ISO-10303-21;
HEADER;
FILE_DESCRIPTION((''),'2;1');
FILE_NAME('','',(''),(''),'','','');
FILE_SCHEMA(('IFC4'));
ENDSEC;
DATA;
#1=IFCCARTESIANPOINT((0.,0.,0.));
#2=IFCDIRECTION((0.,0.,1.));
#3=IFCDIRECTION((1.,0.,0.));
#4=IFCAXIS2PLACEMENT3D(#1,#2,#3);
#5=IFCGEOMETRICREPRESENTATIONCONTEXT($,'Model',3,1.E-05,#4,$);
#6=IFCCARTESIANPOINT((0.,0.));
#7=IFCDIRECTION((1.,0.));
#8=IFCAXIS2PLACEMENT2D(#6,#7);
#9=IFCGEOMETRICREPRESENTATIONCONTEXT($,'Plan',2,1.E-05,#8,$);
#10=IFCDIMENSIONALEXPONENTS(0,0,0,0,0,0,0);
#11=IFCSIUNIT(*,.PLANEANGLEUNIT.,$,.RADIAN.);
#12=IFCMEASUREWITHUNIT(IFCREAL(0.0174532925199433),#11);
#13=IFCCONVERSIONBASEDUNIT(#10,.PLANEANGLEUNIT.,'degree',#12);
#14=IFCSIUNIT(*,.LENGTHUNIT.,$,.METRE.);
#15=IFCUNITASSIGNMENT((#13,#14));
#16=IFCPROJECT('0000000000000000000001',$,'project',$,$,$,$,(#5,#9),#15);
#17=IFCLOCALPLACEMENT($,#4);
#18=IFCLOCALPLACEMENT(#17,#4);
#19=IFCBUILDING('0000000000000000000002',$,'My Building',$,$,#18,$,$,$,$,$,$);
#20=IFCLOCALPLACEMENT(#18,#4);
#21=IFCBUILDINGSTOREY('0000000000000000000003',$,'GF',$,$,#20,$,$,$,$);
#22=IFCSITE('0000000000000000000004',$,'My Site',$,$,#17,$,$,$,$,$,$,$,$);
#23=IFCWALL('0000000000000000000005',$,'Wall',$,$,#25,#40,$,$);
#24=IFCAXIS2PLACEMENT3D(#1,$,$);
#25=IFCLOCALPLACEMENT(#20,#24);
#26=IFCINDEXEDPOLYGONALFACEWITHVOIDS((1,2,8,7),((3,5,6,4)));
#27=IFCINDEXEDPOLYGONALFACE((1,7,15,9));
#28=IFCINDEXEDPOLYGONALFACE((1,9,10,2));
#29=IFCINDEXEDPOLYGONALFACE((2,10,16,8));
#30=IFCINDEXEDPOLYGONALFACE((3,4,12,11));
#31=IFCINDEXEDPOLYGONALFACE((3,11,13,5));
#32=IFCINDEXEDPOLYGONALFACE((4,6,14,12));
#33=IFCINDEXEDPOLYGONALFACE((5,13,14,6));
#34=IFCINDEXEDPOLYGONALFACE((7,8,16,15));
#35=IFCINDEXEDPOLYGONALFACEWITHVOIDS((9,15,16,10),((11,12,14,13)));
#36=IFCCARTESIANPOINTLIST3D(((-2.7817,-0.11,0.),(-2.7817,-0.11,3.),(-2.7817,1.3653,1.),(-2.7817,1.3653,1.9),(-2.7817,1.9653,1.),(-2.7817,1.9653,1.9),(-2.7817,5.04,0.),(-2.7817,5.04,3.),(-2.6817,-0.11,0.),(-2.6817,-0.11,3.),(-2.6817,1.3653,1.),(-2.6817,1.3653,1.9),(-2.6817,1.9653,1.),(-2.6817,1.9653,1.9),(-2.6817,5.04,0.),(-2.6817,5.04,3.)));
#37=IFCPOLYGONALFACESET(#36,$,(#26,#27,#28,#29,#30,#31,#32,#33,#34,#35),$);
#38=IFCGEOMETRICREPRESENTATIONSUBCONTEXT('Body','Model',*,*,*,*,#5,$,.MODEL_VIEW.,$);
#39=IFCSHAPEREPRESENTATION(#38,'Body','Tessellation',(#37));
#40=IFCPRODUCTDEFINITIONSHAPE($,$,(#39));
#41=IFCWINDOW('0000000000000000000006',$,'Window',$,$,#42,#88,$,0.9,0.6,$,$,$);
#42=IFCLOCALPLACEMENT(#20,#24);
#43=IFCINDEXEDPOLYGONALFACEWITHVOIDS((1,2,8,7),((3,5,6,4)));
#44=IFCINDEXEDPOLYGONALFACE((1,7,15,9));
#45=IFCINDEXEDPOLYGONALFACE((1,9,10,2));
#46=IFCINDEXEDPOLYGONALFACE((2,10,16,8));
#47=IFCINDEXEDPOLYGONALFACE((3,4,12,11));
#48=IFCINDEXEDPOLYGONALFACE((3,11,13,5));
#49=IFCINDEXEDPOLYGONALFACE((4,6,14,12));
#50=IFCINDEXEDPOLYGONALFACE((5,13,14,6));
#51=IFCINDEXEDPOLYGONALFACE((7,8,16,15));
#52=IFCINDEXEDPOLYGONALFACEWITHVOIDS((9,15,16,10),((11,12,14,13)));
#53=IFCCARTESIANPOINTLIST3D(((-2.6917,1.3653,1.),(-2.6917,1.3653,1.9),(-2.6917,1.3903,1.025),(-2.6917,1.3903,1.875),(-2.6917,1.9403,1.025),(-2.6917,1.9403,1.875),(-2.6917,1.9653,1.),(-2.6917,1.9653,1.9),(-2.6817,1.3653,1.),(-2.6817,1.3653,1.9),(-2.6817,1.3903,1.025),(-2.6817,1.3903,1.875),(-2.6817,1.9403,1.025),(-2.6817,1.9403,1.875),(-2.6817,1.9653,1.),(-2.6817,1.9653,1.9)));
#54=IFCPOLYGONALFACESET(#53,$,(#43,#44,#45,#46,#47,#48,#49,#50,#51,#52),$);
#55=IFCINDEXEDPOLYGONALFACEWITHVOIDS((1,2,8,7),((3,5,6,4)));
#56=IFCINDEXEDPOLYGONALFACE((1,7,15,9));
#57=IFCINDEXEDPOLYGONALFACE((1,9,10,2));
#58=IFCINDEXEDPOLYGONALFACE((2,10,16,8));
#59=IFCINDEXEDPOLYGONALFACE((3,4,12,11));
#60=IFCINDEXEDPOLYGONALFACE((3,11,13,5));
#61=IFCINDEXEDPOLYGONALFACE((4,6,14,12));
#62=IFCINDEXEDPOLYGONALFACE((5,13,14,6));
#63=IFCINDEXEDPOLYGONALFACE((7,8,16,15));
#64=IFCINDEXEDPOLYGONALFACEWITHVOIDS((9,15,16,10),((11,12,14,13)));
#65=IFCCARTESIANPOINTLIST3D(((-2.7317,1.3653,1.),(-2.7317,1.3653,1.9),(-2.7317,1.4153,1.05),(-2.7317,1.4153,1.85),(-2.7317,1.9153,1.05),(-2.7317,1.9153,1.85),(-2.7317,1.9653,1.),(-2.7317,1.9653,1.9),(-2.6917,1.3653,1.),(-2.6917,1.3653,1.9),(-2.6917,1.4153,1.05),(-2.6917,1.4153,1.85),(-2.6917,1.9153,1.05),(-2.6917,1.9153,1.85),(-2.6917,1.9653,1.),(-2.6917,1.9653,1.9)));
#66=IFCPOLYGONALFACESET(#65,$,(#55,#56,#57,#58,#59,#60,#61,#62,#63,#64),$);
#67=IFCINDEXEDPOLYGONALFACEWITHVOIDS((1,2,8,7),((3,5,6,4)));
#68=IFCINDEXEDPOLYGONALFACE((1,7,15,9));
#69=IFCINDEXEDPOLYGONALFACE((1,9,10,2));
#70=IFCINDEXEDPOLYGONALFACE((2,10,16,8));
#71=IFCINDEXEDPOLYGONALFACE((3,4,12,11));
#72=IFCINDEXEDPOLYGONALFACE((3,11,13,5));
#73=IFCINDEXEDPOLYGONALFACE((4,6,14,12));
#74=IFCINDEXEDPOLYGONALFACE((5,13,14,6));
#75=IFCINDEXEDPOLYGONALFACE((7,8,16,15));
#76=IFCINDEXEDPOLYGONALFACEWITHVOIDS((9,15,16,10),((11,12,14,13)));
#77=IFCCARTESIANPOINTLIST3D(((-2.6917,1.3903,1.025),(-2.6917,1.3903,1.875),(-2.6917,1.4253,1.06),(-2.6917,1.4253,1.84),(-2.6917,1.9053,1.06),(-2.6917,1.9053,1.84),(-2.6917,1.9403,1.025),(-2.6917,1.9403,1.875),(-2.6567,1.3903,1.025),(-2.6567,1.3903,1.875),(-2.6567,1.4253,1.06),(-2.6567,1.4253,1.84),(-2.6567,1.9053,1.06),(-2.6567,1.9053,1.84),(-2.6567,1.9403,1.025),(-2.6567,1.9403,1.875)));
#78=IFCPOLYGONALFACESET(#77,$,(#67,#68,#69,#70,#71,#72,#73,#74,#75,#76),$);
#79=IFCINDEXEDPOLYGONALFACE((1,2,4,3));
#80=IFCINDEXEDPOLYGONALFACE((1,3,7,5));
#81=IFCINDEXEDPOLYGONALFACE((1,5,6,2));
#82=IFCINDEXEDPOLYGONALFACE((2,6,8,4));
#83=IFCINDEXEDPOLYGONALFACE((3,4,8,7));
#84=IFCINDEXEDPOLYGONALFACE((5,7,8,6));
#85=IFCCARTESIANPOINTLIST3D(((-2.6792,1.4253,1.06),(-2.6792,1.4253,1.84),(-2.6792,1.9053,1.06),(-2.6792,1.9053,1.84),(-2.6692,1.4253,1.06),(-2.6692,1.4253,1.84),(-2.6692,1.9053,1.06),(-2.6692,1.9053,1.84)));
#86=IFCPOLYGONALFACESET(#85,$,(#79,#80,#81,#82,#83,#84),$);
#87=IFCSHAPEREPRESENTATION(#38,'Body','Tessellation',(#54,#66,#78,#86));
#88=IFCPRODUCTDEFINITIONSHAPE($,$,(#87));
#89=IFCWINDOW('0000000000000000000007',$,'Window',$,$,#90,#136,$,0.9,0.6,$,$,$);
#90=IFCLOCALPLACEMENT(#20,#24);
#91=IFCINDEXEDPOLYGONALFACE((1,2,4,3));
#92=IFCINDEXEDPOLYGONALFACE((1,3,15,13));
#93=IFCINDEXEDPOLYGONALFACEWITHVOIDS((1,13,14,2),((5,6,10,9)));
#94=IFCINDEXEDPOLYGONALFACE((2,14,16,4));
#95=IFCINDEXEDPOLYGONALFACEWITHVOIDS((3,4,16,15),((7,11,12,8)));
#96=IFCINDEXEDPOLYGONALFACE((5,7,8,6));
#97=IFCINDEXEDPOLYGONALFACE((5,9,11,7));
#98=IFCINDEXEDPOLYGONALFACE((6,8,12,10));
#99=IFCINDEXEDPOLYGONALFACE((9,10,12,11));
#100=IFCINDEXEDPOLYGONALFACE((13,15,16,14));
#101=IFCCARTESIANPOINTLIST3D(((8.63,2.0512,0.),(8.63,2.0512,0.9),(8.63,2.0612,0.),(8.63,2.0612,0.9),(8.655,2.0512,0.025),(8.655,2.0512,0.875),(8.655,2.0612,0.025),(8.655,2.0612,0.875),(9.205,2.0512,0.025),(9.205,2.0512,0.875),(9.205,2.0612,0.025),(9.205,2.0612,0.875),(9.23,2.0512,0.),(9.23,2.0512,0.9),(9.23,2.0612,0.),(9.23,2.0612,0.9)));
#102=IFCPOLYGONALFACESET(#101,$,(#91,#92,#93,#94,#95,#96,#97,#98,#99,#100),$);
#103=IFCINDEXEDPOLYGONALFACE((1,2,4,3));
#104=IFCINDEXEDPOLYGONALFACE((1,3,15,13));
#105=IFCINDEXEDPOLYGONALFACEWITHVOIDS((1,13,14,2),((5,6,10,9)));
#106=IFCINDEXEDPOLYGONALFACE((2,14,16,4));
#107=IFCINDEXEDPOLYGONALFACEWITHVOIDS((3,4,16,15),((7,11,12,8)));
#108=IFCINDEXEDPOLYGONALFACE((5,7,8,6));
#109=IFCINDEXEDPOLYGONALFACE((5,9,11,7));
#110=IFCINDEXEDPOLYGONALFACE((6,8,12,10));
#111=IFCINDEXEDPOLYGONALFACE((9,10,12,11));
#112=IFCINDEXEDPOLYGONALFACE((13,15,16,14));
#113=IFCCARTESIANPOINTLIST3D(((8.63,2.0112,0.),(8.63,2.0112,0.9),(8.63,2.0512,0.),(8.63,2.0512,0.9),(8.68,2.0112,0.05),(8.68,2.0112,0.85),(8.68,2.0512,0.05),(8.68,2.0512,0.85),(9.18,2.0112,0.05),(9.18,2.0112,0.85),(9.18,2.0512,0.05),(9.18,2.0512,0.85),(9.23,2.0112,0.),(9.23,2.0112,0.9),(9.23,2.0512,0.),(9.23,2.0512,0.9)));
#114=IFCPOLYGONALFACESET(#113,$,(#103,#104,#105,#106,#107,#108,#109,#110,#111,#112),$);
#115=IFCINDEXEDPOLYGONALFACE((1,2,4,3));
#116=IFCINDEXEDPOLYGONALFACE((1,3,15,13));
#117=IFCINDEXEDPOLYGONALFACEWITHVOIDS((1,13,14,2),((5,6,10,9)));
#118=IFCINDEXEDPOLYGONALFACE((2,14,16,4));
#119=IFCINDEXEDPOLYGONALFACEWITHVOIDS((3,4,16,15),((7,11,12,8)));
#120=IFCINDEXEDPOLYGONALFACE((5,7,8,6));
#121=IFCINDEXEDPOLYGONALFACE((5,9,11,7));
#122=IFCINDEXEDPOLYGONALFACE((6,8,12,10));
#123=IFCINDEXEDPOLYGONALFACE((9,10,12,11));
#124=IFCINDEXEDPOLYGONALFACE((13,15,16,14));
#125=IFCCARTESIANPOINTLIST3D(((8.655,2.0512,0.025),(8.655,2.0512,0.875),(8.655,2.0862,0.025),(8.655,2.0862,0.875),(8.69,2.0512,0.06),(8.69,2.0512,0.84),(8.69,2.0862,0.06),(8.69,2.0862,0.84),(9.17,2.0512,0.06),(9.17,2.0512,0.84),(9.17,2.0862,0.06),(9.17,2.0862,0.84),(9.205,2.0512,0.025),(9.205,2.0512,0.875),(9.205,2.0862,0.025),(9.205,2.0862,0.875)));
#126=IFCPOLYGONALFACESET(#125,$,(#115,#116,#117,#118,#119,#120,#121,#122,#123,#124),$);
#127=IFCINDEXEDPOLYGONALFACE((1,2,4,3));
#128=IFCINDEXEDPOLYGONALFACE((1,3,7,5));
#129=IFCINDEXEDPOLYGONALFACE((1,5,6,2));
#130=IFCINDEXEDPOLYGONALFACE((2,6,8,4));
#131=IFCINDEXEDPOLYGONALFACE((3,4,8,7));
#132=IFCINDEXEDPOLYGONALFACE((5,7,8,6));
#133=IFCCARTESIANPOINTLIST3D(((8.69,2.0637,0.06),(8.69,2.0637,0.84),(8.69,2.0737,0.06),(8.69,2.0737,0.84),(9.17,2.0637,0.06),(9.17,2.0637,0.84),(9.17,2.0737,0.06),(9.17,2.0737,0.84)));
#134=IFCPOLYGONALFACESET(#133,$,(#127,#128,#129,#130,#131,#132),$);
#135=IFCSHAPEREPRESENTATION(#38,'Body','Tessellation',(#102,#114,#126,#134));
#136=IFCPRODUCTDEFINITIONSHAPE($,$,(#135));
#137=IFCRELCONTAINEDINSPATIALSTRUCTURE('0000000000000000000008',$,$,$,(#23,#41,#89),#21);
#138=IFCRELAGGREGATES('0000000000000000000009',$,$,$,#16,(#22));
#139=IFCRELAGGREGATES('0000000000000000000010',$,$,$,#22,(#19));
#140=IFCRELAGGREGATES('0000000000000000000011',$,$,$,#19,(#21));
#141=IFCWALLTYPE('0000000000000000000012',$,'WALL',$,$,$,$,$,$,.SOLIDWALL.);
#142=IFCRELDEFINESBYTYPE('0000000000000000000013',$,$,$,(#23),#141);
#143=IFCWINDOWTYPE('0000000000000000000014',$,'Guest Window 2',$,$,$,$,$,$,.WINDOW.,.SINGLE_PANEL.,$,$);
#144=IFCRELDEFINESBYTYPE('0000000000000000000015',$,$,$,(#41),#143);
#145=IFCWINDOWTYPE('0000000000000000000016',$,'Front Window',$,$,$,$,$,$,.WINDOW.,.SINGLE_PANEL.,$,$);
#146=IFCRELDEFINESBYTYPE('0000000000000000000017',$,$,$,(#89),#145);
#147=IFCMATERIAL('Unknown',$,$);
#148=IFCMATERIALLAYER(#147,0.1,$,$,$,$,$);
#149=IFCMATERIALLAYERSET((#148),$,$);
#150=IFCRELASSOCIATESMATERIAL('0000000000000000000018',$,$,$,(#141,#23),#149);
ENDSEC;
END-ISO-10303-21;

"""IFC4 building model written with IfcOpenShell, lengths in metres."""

from ifc_helpers import new_model, entity, si_unit, converted_unit, frame, origin_with_axes, origin_2d_with_axis, place, context, subcontext, project, spatial, line, indexed_curve, outline, extrude, shape, source, transform, mapped, material, layer, layer_set, layer_usage, type_object, type_shapes, element, fill, save


model = new_model("IFC4")

# Units and contexts
model_context = context("Model", 3, precision=1e-05, world=origin_with_axes())
plan_context = context("Plan", 2, precision=1e-05, world=origin_2d_with_axis())
body_context_1 = subcontext(model_context, "Body", "Model", "MODEL_VIEW")
body_context_2 = subcontext(plan_context, "Body", "Plan", "PLAN_VIEW")
ifc_project = project(units=[converted_unit("PLANEANGLEUNIT", "degree", entity("IfcReal", 0.0174532925199433), si_unit("PLANEANGLEUNIT", "RADIAN"), dimensions=[0, 0, 0, 0, 0, 0, 0]), si_unit("LENGTHUNIT", "METRE")], contexts=[model_context, plan_context])

# Site, building, storey
site_placement = place(None, origin_with_axes())
site = spatial("IfcSite", under=ifc_project, at=site_placement, Name="My Site")
building_placement = place(site_placement, origin_with_axes())
building = spatial("IfcBuilding", under=site, at=building_placement, Name="My Building")
storey_placement = place(building_placement, origin_with_axes())
storey = spatial("IfcBuildingStorey", under=building, at=storey_placement, Name="GF")

# Shared definitions
ifc_material = material(Name="Unknown")
ifc_layer = layer(ifc_material, 0.1)
ifc_layer_set = layer_set([ifc_layer])
wall_type = type_object("IfcWallType", Name="WALL", PredefinedType="SOLIDWALL", material=ifc_layer_set)
window_type_1 = type_object("IfcWindowType", Name="Front Window", PartitioningType="SINGLE_PANEL", PredefinedType="WINDOW")
shared_shape_1 = source(origin_with_axes(), body_context_1, "Body", "SweptSolid", [
    extrude(outline(indexed_curve([(0.0, 0.0), (0.6, 0.0), (0.6, 0.9), (0.0, 0.9)], segments=[line(1, 2, 3, 4, 1)]), holes=[indexed_curve([(0.025, 0.025), (0.575, 0.025), (0.575, 0.875), (0.025, 0.875)], segments=[line(1, 2, 3, 4, 1)])]), frame((0.0, 0.09, 0.0), z_axis=(0.0, -1.0, 0.0), x_axis=(1.0, 0.0, 0.0)), (0.0, 0.0, -1.0), 0.01),
    extrude(outline(indexed_curve([(0.0, 0.0), (0.6, 0.0), (0.6, 0.9), (0.0, 0.9)], segments=[line(1, 2, 3, 4, 1)]), holes=[indexed_curve([(0.05, 0.05), (0.55, 0.05), (0.55, 0.85), (0.05, 0.85)], segments=[line(1, 2, 3, 4, 1)])]), frame((0.0, 0.05, 0.0), z_axis=(0.0, -1.0, 0.0), x_axis=(1.0, 0.0, 0.0)), (0.0, 0.0, -1.0), 0.04),
    extrude(outline(indexed_curve([(0.0, 0.0), (0.55, 0.0), (0.55, 0.85), (0.0, 0.85)], segments=[line(1, 2, 3, 4, 1)]), holes=[indexed_curve([(0.035, 0.035), (0.515, 0.035), (0.515, 0.815), (0.035, 0.815)], segments=[line(1, 2, 3, 4, 1)])]), frame((0.025, 0.09, 0.025), z_axis=(0.0, -1.0, 0.0), x_axis=(1.0, 0.0, 0.0)), (0.0, 0.0, -1.0), 0.035),
    extrude(outline(indexed_curve([(0.035, 0.035), (0.515, 0.035), (0.515, 0.815), (0.035, 0.815)], segments=[line(1, 2, 3, 4, 1)])), frame((0.025, 0.1025, 0.025), z_axis=(0.0, -1.0, 0.0), x_axis=(1.0, 0.0, 0.0)), (0.0, 0.0, -1.0), 0.01),
])
shared_shape_2 = source(origin_with_axes(), body_context_2, "Body", "Curve2D", [
    entity("IfcIndexedPolyCurve", entity("IfcCartesianPointList2D", [[0.05, 0.05], [0.55, 0.05]])),
    entity("IfcIndexedPolyCurve", entity("IfcCartesianPointList2D", [[0.0, 0.1], [0.025, 0.1], [0.025, 0.09], [0.05, 0.09], [0.05, 0.05], [0.0, 0.05]]), [entity("IfcLineIndex", [1, 2, 3, 4, 5, 6, 1])]),
    entity("IfcIndexedPolyCurve", entity("IfcCartesianPointList2D", [[0.6, 0.1], [0.575, 0.1], [0.575, 0.09], [0.55, 0.09], [0.55, 0.05], [0.6, 0.05]]), [entity("IfcLineIndex", [1, 2, 3, 4, 5, 6, 1])]),
    entity("IfcIndexedPolyCurve", entity("IfcCartesianPointList2D", [[0.025, 0.09], [0.06, 0.09], [0.06, 0.125], [0.025, 0.125]]), [entity("IfcLineIndex", [1, 2, 3, 4, 1])]),
    entity("IfcIndexedPolyCurve", entity("IfcCartesianPointList2D", [[0.575, 0.09], [0.54, 0.09], [0.54, 0.125], [0.575, 0.125]]), [entity("IfcLineIndex", [1, 2, 3, 4, 1])]),
    entity("IfcIndexedPolyCurve", entity("IfcCartesianPointList2D", [[0.06, 0.09], [0.54, 0.09]])),
    entity("IfcIndexedPolyCurve", entity("IfcCartesianPointList2D", [[0.06, 0.125], [0.54, 0.125]])),
    entity("IfcIndexedPolyCurve", entity("IfcCartesianPointList2D", [[0.06, 0.1075], [0.54, 0.1075]])),
])
type_shapes(window_type_1, [shared_shape_1, shared_shape_2])

# Wall, opening, window
ifc_layer_usage_1 = layer_usage(ifc_layer_set, "AXIS2", "POSITIVE", 0.0)
wall_1_placement = place(storey_placement, frame((-2.7817, 5.04, 0.0), z_axis=(0.0, 0.0, 1.0), x_axis=(0.0, -1.0, 0.0)))
wall_1 = element("IfcWall", 1, at=wall_1_placement, inside=storey, type_object=wall_type, material=ifc_layer_usage_1, Name="Wall", context=body_context_1, shape_type="SweptSolid", body=[
    extrude(outline(indexed_curve([(0.0, 0.0), (0.0, 0.1), (5.15, 0.1), (5.15, 0.0)], segments=[line(1, 2, 3, 4, 1)])), origin_with_axes(), (0.0, 0.0, 1.0), 3.0),
])
shared_shape_3 = source(origin_with_axes(), body_context_1, "Body", "SweptSolid", [
    extrude(outline(indexed_curve([(0.0, 0.0), (0.6, 0.0), (0.6, 0.9), (0.0, 0.9)], segments=[line(1, 2, 3, 4, 1)])), frame((0.0, -0.6, 0.0), z_axis=(0.0, -1.0, 0.0), x_axis=(1.0, 0.0, 0.0)), (0.0, 0.0, -1.0), 1.2),
])
opening_1_placement = place(wall_1_placement, frame((3.0746, 0.0, 1.0), z_axis=(0.0, 0.0, 1.0), x_axis=(1.0, 0.0, 0.0)))
opening_1 = element("IfcOpeningElement", 2, at=opening_1_placement, cuts=wall_1, PredefinedType="OPENING", context=body_context_1, shape_type="MappedRepresentation", body=[
    mapped(shared_shape_3, transform((0.0, 0.0, 0.0), x_axis=(1.0, 0.0, 0.0), y_axis=(0.0, 1.0, 0.0), z_axis=(0.0, 0.0, 1.0), scale=1.0)),
])
window_type_2 = type_object("IfcWindowType", Name="Guest Window 2", PartitioningType="SINGLE_PANEL", PredefinedType="WINDOW")
shared_shape_4 = source(origin_with_axes(), body_context_1, "Body", "SweptSolid", [
    extrude(outline(indexed_curve([(0.0, 0.0), (0.6, 0.0), (0.6, 0.9), (0.0, 0.9)], segments=[line(1, 2, 3, 4, 1)]), holes=[indexed_curve([(0.025, 0.025), (0.575, 0.025), (0.575, 0.875), (0.025, 0.875)], segments=[line(1, 2, 3, 4, 1)])]), frame((0.0, 0.09, 0.0), z_axis=(0.0, -1.0, 0.0), x_axis=(1.0, 0.0, 0.0)), (0.0, 0.0, -1.0), 0.01),
    extrude(outline(indexed_curve([(0.0, 0.0), (0.6, 0.0), (0.6, 0.9), (0.0, 0.9)], segments=[line(1, 2, 3, 4, 1)]), holes=[indexed_curve([(0.05, 0.05), (0.55, 0.05), (0.55, 0.85), (0.05, 0.85)], segments=[line(1, 2, 3, 4, 1)])]), frame((0.0, 0.05, 0.0), z_axis=(0.0, -1.0, 0.0), x_axis=(1.0, 0.0, 0.0)), (0.0, 0.0, -1.0), 0.04),
    extrude(outline(indexed_curve([(0.0, 0.0), (0.55, 0.0), (0.55, 0.85), (0.0, 0.85)], segments=[line(1, 2, 3, 4, 1)]), holes=[indexed_curve([(0.035, 0.035), (0.515, 0.035), (0.515, 0.815), (0.035, 0.815)], segments=[line(1, 2, 3, 4, 1)])]), frame((0.025, 0.09, 0.025), z_axis=(0.0, -1.0, 0.0), x_axis=(1.0, 0.0, 0.0)), (0.0, 0.0, -1.0), 0.035),
    extrude(outline(indexed_curve([(0.035, 0.035), (0.515, 0.035), (0.515, 0.815), (0.035, 0.815)], segments=[line(1, 2, 3, 4, 1)])), frame((0.025, 0.1025, 0.025), z_axis=(0.0, -1.0, 0.0), x_axis=(1.0, 0.0, 0.0)), (0.0, 0.0, -1.0), 0.01),
])
shared_shape_5 = source(origin_with_axes(), body_context_2, "Body", "Curve2D", [
    entity("IfcIndexedPolyCurve", entity("IfcCartesianPointList2D", [[0.05, 0.05], [0.55, 0.05]])),
    entity("IfcIndexedPolyCurve", entity("IfcCartesianPointList2D", [[0.0, 0.1], [0.025, 0.1], [0.025, 0.09], [0.05, 0.09], [0.05, 0.05], [0.0, 0.05]]), [entity("IfcLineIndex", [1, 2, 3, 4, 5, 6, 1])]),
    entity("IfcIndexedPolyCurve", entity("IfcCartesianPointList2D", [[0.6, 0.1], [0.575, 0.1], [0.575, 0.09], [0.55, 0.09], [0.55, 0.05], [0.6, 0.05]]), [entity("IfcLineIndex", [1, 2, 3, 4, 5, 6, 1])]),
    entity("IfcIndexedPolyCurve", entity("IfcCartesianPointList2D", [[0.025, 0.09], [0.06, 0.09], [0.06, 0.125], [0.025, 0.125]]), [entity("IfcLineIndex", [1, 2, 3, 4, 1])]),
    entity("IfcIndexedPolyCurve", entity("IfcCartesianPointList2D", [[0.575, 0.09], [0.54, 0.09], [0.54, 0.125], [0.575, 0.125]]), [entity("IfcLineIndex", [1, 2, 3, 4, 1])]),
    entity("IfcIndexedPolyCurve", entity("IfcCartesianPointList2D", [[0.06, 0.09], [0.54, 0.09]])),
    entity("IfcIndexedPolyCurve", entity("IfcCartesianPointList2D", [[0.06, 0.125], [0.54, 0.125]])),
    entity("IfcIndexedPolyCurve", entity("IfcCartesianPointList2D", [[0.06, 0.1075], [0.54, 0.1075]])),
])
type_shapes(window_type_2, [shared_shape_4, shared_shape_5])
window_1_placement = place(opening_1_placement, frame((0.0, 0.0, 0.0), z_axis=(0.0, 0.0, 1.0), x_axis=(1.0, 0.0, 0.0)))
window_1 = element("IfcWindow", 3, at=window_1_placement, inside=storey, type_object=window_type_2, Name="Window", OverallHeight=0.9, OverallWidth=0.6, shapes=[
    shape(body_context_1, "Body", "MappedRepresentation", [mapped(shared_shape_4, transform((0.0, 0.0, 0.0), x_axis=(1.0, 0.0, 0.0), y_axis=(0.0, 1.0, 0.0), z_axis=(0.0, 0.0, 1.0), scale=1.0))]),
    shape(body_context_2, "Body", "MappedRepresentation", [mapped(shared_shape_5, transform((0.0, 0.0, 0.0), x_axis=(1.0, 0.0, 0.0), y_axis=(0.0, 1.0, 0.0), z_axis=(0.0, 0.0, 1.0), scale=1.0))]),
])
fill(opening_1, window_1)

# Window
for number, where, z_axis, x_axis, name in (
    (4, (8.63, 1.9612, 0.0), (0.0, 0.0, 1.0), (1.0, 0.0, 0.0), "Window"),
):
    element("IfcWindow", number, at=place(storey_placement, frame(where, z_axis=z_axis, x_axis=x_axis)), inside=storey, type_object=window_type_1, Name=name, OverallHeight=0.9, OverallWidth=0.6, shapes=[
        shape(body_context_1, "Body", "MappedRepresentation", [mapped(shared_shape_1, transform((0.0, 0.0, 0.0), x_axis=(1.0, 0.0, 0.0), y_axis=(0.0, 1.0, 0.0), z_axis=(0.0, 0.0, 1.0), scale=1.0))]),
        shape(body_context_2, "Body", "MappedRepresentation", [mapped(shared_shape_2, transform((0.0, 0.0, 0.0), x_axis=(1.0, 0.0, 0.0), y_axis=(0.0, 1.0, 0.0), z_axis=(0.0, 0.0, 1.0), scale=1.0))]),
    ])

save(model, "model.ifc")
